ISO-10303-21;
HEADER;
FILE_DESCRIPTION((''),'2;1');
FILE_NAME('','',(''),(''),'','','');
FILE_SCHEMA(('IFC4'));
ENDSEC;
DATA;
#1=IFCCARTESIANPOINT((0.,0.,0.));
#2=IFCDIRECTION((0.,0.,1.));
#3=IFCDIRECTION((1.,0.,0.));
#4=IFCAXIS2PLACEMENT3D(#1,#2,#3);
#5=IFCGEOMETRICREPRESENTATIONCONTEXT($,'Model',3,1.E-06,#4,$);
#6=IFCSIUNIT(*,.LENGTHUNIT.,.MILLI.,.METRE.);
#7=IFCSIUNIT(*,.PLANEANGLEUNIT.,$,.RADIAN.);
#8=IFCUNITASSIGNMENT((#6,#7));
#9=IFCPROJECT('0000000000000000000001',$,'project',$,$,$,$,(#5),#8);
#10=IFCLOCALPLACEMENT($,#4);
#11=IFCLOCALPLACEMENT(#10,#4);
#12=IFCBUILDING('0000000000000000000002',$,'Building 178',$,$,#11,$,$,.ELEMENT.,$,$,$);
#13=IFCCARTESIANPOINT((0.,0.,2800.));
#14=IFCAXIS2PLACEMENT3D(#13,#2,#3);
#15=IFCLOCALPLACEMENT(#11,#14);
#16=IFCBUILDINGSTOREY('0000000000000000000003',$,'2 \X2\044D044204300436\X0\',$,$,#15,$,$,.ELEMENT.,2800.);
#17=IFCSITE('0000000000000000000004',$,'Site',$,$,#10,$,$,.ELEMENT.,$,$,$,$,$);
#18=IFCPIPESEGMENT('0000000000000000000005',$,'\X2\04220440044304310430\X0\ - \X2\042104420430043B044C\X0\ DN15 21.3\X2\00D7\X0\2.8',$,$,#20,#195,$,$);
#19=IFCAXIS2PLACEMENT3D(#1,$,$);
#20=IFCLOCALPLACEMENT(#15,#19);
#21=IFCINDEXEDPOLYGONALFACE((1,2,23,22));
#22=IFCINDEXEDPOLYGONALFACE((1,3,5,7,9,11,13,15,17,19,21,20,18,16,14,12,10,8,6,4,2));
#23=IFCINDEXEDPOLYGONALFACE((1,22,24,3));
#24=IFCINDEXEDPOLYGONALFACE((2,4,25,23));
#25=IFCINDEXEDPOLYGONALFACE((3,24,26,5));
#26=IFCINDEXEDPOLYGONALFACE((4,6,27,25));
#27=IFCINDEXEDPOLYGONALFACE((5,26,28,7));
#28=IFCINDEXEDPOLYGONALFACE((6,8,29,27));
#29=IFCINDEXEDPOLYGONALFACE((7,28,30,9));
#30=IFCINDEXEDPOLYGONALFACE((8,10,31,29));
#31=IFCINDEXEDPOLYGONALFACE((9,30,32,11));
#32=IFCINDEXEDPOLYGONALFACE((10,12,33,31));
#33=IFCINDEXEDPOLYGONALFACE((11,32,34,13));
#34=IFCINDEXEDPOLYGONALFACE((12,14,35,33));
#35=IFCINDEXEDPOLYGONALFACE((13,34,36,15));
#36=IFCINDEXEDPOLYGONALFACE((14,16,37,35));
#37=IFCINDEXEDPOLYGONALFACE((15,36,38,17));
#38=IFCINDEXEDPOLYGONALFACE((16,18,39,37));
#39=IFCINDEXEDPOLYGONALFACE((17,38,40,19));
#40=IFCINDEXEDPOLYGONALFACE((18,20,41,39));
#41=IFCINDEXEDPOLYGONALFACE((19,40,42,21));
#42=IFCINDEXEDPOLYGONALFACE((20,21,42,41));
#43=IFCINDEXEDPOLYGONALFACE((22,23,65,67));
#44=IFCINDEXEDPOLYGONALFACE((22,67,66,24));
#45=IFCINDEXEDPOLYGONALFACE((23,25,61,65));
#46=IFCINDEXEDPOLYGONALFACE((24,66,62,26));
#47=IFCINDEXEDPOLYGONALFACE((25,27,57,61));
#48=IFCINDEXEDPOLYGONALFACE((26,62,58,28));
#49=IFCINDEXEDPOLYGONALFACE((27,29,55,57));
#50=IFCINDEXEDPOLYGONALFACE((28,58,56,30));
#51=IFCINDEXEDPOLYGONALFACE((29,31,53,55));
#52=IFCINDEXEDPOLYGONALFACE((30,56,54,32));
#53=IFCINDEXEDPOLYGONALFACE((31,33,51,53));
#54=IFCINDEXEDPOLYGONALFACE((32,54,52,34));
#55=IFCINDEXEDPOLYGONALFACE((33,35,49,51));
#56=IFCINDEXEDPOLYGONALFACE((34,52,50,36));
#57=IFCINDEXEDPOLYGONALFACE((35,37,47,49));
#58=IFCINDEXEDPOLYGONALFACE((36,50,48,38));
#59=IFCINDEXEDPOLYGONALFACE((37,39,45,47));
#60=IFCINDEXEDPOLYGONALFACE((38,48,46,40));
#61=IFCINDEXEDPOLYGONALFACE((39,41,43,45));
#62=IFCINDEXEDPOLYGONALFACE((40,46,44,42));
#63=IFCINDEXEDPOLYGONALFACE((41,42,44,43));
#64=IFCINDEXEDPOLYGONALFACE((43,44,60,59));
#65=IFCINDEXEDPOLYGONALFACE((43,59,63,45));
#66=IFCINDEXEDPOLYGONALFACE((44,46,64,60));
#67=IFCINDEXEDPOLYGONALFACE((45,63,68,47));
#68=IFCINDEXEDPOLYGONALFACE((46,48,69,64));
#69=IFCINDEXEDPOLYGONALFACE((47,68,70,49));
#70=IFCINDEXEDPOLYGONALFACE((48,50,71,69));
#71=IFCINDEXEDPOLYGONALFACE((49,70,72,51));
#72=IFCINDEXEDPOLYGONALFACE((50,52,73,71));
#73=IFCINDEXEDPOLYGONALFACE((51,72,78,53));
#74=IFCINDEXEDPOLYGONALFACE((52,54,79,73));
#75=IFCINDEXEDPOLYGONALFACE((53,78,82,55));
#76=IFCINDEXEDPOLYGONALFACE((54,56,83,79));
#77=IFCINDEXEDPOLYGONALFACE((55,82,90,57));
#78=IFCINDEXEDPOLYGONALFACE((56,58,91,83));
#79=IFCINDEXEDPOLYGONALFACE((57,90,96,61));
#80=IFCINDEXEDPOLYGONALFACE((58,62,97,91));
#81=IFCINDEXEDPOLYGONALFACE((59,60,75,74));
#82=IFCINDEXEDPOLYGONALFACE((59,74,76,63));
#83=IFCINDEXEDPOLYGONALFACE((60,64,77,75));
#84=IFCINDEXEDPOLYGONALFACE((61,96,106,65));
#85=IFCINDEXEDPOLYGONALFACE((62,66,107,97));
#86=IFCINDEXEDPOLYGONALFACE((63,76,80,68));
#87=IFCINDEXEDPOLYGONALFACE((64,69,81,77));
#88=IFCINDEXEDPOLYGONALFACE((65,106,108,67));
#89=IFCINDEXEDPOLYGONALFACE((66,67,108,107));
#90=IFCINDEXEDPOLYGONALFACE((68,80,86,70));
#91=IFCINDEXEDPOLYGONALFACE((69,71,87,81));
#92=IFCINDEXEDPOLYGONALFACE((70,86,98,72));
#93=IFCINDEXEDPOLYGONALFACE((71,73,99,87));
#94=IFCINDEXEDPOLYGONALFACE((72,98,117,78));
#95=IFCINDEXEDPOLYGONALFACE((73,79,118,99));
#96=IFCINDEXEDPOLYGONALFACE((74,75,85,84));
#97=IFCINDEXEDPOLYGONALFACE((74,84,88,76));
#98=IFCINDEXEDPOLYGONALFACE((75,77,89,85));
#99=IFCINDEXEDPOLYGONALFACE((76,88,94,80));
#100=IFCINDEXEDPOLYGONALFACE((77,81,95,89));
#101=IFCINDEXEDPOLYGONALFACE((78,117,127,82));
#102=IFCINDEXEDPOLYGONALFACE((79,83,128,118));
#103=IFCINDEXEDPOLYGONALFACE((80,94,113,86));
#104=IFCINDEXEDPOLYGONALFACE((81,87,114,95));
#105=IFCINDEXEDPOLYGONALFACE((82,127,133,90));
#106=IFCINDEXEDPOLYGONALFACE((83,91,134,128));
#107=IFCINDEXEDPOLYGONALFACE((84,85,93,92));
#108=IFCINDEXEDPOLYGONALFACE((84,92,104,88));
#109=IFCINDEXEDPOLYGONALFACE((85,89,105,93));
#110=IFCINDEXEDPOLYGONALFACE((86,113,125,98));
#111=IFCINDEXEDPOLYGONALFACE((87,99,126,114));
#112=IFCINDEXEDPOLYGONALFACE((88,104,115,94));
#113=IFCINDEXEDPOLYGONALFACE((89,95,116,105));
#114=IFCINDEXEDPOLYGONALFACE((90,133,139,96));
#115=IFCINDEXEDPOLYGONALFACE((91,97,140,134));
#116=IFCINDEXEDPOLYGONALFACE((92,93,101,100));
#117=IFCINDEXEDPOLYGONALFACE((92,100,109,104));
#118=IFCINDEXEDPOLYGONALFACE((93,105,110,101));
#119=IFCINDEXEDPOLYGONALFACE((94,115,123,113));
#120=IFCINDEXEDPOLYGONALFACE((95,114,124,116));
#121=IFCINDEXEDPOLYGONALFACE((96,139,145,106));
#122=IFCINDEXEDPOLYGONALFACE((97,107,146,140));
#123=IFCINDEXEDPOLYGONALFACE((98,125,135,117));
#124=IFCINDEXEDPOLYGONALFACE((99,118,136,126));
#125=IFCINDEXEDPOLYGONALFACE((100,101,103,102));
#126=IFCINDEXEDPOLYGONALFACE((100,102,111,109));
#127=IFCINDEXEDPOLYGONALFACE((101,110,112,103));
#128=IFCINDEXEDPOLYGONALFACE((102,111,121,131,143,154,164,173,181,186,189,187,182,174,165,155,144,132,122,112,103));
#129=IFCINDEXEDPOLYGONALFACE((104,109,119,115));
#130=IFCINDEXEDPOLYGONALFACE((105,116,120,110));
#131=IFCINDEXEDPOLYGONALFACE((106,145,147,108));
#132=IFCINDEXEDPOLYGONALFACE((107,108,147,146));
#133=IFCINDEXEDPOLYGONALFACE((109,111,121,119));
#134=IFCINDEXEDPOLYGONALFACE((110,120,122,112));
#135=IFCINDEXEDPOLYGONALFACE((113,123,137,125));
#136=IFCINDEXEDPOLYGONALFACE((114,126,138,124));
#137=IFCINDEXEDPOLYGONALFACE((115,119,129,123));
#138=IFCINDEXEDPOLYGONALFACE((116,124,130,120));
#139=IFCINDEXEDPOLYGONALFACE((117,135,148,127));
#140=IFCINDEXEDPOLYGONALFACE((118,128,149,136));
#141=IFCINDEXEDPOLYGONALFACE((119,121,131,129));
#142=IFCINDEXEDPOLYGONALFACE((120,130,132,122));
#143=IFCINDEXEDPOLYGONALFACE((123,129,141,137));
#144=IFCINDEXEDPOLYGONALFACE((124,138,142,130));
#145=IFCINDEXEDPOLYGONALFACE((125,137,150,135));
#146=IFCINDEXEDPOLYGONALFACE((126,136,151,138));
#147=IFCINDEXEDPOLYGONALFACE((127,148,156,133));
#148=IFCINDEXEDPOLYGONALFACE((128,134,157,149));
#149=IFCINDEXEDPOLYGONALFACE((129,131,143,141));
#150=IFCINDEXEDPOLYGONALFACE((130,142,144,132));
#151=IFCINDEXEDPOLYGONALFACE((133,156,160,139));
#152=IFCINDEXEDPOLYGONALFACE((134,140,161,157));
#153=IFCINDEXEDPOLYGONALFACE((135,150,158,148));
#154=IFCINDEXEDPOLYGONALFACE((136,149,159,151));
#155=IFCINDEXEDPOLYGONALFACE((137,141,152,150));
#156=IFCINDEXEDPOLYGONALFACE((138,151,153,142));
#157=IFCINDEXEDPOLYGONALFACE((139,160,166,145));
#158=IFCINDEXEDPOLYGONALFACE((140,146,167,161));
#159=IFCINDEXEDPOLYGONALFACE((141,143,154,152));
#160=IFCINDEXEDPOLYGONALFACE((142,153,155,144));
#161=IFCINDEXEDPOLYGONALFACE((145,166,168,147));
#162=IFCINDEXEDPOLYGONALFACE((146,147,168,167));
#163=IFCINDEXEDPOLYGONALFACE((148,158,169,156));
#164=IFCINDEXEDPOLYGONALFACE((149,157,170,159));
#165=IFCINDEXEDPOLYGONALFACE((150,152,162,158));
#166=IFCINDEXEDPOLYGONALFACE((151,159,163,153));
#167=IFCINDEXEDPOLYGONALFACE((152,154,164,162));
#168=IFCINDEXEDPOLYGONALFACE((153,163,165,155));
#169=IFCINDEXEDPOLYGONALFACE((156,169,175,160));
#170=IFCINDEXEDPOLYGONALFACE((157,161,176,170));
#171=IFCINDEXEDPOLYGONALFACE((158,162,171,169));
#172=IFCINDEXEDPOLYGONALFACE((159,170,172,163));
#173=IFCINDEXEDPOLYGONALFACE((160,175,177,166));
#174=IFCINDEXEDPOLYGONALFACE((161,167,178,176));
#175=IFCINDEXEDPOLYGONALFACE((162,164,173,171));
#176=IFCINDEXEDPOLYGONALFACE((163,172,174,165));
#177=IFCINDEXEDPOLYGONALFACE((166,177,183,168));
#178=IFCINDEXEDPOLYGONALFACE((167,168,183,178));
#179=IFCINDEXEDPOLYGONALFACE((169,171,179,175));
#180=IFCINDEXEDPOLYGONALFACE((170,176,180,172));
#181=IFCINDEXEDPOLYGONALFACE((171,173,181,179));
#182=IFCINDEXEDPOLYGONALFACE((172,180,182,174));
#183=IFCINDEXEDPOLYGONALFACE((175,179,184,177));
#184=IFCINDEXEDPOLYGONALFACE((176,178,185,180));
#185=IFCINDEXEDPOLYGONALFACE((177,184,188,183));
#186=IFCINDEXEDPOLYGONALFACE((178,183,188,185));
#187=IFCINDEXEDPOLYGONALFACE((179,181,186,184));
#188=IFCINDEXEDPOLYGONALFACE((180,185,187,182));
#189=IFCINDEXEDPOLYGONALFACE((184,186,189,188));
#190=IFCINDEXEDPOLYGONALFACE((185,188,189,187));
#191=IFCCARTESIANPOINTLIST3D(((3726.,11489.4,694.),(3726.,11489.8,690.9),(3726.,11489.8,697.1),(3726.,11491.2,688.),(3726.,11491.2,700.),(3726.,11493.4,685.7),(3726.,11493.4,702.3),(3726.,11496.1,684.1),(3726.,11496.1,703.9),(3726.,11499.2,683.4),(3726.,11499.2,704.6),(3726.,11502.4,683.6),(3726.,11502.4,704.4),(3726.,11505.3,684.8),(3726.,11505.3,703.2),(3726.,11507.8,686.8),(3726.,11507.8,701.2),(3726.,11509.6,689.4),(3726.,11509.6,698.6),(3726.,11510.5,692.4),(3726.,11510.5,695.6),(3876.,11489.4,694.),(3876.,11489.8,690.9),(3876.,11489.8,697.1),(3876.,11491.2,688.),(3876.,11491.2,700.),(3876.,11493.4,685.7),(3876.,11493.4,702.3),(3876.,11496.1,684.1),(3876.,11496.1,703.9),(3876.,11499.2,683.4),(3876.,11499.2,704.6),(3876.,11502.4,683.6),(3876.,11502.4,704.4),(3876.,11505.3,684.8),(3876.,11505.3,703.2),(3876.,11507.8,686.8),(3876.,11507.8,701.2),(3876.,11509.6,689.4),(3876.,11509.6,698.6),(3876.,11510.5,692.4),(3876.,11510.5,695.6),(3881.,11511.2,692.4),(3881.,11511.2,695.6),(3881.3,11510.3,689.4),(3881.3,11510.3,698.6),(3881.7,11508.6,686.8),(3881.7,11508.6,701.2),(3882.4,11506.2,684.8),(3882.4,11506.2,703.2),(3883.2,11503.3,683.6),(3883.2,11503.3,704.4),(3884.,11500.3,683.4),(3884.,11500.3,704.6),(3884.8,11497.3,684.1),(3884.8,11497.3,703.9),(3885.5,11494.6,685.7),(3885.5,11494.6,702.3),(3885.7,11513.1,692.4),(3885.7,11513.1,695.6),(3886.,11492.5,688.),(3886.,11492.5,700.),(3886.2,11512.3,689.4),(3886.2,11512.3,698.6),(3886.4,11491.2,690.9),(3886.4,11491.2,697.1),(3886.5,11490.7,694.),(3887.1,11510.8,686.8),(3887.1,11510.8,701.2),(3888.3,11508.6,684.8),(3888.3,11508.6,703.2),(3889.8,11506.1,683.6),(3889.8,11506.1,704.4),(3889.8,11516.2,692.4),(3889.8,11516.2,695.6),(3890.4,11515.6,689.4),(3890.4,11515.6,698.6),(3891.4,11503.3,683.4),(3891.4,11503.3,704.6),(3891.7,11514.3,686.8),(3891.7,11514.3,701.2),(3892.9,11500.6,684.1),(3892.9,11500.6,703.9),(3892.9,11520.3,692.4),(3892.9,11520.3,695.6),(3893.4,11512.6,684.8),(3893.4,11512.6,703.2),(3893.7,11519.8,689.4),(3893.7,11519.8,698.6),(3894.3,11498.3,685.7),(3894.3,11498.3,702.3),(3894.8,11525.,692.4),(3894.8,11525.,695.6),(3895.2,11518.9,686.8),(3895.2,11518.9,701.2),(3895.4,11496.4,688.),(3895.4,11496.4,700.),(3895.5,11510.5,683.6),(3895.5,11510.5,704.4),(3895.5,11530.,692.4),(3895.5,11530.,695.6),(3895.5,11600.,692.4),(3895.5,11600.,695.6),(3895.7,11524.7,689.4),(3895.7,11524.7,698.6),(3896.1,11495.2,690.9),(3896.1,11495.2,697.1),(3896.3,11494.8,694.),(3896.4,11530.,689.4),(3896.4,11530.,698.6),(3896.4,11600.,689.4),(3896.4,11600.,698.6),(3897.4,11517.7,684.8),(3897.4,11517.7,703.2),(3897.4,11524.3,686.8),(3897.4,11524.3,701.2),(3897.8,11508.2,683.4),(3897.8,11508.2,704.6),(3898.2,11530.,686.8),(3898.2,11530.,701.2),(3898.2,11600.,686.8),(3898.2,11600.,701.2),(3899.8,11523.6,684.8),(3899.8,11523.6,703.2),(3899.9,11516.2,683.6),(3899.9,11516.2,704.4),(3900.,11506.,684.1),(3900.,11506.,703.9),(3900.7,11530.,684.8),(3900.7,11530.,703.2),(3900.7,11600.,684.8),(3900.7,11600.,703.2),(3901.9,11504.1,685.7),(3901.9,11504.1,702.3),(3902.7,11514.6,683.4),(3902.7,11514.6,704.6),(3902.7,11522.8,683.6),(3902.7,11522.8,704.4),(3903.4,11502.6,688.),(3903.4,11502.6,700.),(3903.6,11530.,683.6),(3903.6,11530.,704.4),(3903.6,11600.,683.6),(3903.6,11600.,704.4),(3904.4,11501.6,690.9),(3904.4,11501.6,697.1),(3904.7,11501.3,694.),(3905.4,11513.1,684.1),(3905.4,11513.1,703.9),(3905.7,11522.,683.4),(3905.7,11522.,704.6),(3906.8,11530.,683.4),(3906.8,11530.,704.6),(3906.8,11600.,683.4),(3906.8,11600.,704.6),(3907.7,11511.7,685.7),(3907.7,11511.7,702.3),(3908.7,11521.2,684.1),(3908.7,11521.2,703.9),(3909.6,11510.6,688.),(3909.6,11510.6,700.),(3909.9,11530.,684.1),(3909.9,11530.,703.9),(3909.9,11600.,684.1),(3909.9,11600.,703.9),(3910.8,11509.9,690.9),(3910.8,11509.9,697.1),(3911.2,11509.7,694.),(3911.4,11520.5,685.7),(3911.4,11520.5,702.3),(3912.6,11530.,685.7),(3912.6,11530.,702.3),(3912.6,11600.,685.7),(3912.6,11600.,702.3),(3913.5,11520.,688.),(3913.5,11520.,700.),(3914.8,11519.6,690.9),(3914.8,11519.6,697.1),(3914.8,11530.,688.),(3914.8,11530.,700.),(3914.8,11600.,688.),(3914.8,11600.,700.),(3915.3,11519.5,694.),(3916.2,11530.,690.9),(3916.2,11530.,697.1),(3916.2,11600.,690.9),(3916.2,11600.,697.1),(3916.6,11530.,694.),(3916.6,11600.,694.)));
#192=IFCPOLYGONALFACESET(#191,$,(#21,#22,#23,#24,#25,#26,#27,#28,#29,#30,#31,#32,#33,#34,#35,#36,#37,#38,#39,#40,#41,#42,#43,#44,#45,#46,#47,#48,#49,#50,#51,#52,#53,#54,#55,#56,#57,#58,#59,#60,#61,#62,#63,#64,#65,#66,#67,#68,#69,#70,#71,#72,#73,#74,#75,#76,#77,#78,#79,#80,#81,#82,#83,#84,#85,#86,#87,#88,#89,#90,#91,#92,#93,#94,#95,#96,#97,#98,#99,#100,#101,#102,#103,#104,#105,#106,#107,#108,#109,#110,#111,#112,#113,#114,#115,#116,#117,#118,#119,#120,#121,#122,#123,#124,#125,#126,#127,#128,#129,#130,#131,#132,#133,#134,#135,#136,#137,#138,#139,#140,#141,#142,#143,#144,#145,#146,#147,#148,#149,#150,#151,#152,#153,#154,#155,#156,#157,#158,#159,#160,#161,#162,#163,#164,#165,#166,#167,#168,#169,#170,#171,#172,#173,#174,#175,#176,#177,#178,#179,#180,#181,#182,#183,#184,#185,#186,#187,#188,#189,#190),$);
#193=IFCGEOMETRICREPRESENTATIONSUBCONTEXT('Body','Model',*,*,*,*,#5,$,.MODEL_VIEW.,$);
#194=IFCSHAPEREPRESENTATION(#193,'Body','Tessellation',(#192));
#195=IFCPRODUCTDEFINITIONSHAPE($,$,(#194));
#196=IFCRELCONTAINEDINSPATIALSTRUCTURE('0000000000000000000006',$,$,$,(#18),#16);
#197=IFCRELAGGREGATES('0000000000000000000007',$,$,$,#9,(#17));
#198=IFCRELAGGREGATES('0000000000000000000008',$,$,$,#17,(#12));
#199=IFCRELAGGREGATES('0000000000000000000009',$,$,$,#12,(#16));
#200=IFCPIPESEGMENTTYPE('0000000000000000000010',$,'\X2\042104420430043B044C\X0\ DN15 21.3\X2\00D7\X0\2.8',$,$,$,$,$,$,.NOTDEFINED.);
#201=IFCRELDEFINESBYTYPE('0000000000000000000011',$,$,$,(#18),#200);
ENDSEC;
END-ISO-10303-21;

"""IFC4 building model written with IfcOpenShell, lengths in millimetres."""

from ifc_helpers import new_model, entity, si_unit, frame, origin_with_axes, place, context, subcontext, project, spatial, source, transform, mapped, type_object, element, save


model = new_model("IFC4")

# Units and contexts
model_context = context("Model", 3, precision=1e-06, world=origin_with_axes())
body_context = subcontext(model_context, "Body", "Model", "MODEL_VIEW")
ifc_project = project(units=[si_unit("LENGTHUNIT", "METRE", prefix="MILLI"), si_unit("PLANEANGLEUNIT", "RADIAN")], contexts=[model_context])

# Site, building, storey
site_placement = place(None, origin_with_axes())
site = spatial("IfcSite", under=ifc_project, at=site_placement, Name="Site", CompositionType="ELEMENT")
building_placement = place(site_placement, origin_with_axes())
building = spatial("IfcBuilding", under=site, at=building_placement, Name="Building 178", CompositionType="ELEMENT")
storey_placement = place(building_placement, frame((0.0, 0.0, 2800.0), z_axis=(0.0, 0.0, 1.0), x_axis=(1.0, 0.0, 0.0)))
storey = spatial("IfcBuildingStorey", under=building, at=storey_placement, Name="2 этаж", CompositionType="ELEMENT", Elevation=2800.0)

# Pipe segment
pipe_segment_type = type_object("IfcPipeSegmentType", Name="Сталь DN15 21.3×2.8", PredefinedType="NOTDEFINED")
shared_shape_1 = source(origin_with_axes(), body_context, "Body", "AdvancedSweptSolid", [
    entity("IfcSweptDiskSolid", entity("IfcIndexedPolyCurve", entity("IfcCartesianPointList3D", [[0.0, 0.0, 0.0], [0.0, 0.0, -70.0], [8.8, 0.0, -91.2], [30.0, 0.0, -100.0], [180.0, 0.0, -100.0]]), [entity("IfcLineIndex", [1, 2]), entity("IfcArcIndex", [2, 3, 4]), entity("IfcLineIndex", [4, 5])]), 10.7),
])
for number, where, z_axis, x_axis, name in (
    (1, (3906.0, 11600.0, 694.0), (0.0, 1.0, 0.0), (-1.0, 0.0, 0.0), "Труба - Сталь DN15 21.3×2.8"),
):
    element("IfcPipeSegment", number, at=place(storey_placement, frame(where, z_axis=z_axis, x_axis=x_axis)), inside=storey, type_object=pipe_segment_type, Name=name, context=body_context, shape_type="MappedRepresentation", body=[
        mapped(shared_shape_1, transform((0.0, 0.0, 0.0), x_axis=(1.0, 0.0, 0.0), y_axis=(0.0, 1.0, 0.0), z_axis=(0.0, 0.0, 1.0), scale=1.0)),
    ])

save(model, "model.ifc")
